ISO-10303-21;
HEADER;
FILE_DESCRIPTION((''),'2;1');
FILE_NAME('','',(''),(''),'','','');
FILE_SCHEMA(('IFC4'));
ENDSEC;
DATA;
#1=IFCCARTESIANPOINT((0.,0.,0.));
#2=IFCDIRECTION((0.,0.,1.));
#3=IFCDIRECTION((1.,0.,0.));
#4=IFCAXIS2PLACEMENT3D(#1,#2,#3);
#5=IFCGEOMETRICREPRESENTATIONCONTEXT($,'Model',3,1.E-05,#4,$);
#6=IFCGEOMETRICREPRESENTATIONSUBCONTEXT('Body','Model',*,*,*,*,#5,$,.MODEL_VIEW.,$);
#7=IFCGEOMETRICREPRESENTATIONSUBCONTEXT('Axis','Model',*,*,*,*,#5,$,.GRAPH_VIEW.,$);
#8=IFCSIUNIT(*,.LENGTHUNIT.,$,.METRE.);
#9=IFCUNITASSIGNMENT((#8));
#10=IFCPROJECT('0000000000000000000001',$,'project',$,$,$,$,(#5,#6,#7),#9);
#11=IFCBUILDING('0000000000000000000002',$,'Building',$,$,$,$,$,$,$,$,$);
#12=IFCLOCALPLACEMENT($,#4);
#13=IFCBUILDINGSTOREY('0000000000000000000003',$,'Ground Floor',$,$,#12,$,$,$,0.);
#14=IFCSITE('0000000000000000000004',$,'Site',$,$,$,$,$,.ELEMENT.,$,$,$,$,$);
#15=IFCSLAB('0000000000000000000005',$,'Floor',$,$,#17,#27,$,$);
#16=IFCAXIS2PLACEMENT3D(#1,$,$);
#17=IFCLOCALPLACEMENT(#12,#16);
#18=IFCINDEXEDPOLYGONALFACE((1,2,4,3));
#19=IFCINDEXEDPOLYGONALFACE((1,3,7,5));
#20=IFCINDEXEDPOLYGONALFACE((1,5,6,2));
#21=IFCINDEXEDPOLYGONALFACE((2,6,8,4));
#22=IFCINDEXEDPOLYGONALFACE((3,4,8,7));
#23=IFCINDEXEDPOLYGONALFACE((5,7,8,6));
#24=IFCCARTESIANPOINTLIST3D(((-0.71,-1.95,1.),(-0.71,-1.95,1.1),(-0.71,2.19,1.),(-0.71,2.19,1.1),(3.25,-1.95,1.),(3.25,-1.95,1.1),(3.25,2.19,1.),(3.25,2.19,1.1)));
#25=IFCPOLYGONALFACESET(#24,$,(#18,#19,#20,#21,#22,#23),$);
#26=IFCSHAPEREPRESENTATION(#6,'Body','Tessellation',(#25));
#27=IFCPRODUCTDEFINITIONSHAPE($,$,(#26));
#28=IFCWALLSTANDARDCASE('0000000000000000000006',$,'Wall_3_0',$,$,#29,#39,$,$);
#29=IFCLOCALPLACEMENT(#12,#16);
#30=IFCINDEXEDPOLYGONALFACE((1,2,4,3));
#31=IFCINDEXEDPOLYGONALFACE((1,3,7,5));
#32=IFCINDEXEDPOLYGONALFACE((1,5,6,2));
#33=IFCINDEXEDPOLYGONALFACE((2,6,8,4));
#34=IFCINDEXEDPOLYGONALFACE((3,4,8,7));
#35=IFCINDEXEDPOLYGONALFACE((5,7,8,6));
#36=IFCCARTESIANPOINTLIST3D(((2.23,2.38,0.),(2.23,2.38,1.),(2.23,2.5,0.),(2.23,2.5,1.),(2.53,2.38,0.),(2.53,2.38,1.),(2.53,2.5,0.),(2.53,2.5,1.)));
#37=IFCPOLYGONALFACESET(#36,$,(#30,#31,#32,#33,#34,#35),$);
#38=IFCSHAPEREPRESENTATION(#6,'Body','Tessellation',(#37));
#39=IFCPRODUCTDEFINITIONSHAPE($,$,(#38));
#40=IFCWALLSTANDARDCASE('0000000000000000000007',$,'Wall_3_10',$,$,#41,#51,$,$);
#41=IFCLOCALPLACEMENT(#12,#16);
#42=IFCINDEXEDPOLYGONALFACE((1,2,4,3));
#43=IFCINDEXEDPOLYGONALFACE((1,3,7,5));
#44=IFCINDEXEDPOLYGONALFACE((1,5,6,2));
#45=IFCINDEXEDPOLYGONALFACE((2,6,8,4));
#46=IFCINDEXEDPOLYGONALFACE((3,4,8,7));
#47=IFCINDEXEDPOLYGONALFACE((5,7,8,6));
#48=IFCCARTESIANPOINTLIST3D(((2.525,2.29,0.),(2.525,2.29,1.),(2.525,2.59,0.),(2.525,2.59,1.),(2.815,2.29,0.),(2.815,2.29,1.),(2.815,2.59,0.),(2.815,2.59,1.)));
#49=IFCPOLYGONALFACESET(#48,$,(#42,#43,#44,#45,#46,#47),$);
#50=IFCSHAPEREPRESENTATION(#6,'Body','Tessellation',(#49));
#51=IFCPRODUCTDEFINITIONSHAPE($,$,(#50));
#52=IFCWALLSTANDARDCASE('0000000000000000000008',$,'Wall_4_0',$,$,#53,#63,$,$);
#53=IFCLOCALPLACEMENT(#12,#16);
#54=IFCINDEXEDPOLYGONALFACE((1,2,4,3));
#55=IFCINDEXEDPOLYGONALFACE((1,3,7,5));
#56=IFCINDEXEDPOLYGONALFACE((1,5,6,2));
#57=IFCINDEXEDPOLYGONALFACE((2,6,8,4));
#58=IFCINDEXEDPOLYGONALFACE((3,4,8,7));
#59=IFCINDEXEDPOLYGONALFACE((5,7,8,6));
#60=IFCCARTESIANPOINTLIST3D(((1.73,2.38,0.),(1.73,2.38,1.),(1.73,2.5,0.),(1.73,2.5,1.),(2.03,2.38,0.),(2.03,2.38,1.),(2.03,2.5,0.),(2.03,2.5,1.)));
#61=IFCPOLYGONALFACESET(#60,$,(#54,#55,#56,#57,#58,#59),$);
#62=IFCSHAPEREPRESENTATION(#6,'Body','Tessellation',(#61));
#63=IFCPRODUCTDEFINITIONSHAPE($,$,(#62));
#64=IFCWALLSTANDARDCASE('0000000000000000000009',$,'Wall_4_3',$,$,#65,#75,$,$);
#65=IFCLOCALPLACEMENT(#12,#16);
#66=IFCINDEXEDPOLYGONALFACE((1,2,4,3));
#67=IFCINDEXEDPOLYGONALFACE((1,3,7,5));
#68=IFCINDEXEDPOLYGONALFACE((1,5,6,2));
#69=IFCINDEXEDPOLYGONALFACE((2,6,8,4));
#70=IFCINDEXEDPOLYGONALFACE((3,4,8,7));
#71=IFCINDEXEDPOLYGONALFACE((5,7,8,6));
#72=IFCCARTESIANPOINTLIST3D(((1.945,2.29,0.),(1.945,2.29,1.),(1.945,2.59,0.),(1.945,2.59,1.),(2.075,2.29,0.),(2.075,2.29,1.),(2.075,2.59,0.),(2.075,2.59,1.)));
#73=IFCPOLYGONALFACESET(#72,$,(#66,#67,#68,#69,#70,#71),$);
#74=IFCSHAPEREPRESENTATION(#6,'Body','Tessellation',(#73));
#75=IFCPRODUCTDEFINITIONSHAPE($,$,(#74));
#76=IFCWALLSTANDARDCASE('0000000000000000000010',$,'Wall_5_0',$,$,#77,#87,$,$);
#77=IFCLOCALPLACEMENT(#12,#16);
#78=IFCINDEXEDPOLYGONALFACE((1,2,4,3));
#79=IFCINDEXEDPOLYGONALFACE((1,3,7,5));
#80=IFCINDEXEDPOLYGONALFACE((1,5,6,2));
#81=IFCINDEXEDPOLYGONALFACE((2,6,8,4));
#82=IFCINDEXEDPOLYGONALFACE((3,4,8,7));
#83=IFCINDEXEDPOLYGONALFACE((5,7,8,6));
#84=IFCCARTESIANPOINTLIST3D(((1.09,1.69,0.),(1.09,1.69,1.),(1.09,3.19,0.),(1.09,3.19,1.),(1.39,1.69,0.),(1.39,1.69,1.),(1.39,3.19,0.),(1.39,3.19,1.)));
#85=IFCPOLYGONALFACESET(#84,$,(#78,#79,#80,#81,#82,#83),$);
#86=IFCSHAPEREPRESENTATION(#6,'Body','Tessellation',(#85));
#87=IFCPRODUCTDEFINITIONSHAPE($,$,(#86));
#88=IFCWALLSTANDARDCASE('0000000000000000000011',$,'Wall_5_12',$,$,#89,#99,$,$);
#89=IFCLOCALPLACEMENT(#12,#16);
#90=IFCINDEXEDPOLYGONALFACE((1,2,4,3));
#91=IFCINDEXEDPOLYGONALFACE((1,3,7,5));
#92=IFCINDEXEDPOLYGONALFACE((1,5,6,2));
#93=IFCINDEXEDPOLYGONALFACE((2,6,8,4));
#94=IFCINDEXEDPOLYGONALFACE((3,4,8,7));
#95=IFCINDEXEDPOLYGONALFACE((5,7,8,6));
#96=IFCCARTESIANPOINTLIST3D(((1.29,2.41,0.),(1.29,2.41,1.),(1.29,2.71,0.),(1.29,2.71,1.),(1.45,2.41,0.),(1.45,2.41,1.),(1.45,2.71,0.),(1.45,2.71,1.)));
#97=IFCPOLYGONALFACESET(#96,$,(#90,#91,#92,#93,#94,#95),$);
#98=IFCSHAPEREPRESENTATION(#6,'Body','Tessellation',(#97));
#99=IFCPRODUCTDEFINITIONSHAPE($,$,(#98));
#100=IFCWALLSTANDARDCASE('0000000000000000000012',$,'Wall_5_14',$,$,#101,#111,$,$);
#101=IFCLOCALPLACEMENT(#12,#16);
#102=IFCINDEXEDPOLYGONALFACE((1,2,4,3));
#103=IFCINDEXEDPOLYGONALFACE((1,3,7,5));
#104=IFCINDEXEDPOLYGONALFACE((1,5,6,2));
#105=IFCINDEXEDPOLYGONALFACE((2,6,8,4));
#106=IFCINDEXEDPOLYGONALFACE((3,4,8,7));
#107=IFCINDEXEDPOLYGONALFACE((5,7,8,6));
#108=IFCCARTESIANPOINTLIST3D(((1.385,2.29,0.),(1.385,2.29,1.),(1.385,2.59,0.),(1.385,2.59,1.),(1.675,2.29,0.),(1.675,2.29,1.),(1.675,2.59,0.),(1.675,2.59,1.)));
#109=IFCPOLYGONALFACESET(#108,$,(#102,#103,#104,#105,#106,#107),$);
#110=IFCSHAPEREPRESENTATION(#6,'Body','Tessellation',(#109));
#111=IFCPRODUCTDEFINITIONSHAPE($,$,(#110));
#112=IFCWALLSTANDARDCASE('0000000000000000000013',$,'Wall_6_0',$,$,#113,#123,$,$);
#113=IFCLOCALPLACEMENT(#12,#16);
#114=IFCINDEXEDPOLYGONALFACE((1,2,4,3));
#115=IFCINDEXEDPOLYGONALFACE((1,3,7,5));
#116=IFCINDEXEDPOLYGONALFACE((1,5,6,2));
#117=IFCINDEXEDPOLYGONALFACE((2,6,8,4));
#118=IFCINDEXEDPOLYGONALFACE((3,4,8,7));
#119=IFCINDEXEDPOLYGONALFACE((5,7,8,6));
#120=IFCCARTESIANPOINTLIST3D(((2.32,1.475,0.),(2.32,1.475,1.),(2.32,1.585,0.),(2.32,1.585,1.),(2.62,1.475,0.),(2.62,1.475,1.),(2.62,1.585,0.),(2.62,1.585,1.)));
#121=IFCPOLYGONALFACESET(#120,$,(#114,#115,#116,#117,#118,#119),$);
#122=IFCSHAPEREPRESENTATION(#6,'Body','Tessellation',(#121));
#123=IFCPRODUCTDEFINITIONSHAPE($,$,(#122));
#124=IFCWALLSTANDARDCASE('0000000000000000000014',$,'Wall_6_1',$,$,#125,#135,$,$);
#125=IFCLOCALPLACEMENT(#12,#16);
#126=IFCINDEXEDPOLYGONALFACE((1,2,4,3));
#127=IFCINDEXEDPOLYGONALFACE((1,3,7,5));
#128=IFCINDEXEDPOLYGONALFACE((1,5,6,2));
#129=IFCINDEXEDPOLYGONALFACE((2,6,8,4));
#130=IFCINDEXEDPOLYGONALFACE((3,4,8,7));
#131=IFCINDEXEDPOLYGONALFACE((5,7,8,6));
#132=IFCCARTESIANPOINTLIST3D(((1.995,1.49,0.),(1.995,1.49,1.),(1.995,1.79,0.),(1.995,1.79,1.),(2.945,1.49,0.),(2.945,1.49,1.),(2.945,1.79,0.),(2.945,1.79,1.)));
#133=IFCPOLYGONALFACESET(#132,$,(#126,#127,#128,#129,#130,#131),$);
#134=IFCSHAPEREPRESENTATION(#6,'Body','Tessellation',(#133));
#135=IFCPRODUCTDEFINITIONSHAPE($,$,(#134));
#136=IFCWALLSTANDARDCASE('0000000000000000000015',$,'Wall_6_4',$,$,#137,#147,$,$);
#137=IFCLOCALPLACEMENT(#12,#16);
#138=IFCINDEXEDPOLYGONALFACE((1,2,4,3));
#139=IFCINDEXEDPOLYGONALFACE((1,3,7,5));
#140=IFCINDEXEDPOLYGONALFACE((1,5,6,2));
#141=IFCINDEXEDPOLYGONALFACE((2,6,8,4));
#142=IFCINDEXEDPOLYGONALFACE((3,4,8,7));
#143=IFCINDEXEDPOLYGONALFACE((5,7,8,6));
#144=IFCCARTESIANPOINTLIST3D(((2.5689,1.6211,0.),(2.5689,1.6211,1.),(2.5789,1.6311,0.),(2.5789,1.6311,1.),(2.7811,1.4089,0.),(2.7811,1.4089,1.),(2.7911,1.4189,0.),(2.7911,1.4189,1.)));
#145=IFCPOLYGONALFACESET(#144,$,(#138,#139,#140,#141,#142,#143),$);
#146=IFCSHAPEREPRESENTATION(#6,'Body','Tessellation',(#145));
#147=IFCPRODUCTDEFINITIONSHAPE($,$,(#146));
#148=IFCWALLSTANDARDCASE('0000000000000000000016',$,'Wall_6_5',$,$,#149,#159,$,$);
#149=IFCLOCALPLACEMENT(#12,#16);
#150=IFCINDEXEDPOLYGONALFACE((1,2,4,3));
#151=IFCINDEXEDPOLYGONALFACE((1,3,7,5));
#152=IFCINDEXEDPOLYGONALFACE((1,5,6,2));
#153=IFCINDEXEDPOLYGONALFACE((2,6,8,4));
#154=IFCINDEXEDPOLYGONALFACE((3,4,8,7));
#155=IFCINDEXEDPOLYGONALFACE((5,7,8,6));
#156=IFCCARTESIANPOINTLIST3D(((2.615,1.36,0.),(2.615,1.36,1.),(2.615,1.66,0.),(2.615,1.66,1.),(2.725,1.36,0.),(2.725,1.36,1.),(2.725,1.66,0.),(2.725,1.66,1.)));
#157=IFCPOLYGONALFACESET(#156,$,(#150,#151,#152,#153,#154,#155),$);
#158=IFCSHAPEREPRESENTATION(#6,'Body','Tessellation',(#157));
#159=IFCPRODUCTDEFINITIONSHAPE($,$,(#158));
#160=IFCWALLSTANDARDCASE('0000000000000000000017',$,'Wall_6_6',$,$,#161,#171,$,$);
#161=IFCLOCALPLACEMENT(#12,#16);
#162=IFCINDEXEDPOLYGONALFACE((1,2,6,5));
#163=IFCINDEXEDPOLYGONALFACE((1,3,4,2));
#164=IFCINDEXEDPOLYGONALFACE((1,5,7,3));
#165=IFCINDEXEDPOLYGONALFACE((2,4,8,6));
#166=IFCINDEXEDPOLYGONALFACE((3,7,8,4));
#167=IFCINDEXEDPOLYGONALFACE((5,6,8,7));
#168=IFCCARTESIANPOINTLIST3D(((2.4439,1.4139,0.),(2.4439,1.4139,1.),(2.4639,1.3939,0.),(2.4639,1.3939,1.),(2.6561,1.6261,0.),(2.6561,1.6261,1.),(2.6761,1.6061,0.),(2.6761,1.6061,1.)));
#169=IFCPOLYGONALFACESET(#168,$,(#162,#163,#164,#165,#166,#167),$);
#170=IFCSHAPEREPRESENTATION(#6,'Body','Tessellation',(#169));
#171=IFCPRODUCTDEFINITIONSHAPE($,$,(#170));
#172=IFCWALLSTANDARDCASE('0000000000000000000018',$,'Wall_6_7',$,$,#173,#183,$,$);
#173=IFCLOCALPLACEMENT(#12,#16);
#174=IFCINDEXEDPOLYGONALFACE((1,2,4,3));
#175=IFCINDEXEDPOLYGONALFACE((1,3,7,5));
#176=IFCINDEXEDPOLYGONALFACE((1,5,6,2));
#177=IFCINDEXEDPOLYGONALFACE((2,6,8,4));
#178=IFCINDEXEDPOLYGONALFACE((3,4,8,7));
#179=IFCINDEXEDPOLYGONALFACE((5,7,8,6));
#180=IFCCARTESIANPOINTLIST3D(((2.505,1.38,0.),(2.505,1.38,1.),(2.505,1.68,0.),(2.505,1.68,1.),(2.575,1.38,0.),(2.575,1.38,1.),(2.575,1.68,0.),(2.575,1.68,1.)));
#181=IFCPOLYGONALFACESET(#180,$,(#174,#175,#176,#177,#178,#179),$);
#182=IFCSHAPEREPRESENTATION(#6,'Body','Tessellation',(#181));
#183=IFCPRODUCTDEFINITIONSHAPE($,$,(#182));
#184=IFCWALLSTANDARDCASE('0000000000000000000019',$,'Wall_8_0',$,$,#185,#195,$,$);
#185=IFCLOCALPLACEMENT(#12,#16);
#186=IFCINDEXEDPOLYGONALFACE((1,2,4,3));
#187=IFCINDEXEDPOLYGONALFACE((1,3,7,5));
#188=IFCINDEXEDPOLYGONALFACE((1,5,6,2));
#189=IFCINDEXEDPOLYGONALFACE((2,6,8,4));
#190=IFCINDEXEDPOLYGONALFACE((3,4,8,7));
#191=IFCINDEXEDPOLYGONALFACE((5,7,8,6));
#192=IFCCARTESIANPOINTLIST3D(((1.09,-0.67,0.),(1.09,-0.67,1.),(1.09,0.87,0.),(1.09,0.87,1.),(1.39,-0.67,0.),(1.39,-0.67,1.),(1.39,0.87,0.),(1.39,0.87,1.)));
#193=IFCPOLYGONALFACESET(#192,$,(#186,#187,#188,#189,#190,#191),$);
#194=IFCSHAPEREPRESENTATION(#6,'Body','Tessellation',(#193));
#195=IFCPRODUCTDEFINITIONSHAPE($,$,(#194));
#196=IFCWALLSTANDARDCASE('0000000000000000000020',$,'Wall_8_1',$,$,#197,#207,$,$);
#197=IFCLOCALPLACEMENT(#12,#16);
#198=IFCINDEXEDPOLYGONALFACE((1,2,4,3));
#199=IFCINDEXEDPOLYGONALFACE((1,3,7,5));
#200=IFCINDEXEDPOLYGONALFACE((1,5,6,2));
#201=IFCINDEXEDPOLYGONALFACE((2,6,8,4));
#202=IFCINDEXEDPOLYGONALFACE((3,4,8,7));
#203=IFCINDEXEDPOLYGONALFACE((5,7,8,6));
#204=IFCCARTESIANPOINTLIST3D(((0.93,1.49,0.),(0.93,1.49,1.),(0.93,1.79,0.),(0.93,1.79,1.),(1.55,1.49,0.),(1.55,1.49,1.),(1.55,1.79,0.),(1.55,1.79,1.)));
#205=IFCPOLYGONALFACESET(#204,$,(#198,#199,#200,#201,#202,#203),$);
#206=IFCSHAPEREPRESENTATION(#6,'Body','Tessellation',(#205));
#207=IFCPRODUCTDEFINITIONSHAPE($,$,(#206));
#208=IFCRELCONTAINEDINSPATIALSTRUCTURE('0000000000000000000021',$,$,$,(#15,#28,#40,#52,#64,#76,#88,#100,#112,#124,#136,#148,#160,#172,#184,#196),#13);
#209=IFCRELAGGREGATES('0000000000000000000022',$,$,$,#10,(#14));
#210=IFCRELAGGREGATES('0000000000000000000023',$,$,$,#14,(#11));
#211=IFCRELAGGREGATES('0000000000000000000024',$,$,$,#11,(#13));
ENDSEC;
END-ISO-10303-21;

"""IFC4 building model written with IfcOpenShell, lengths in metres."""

from ifc_helpers import new_model, si_unit, frame, origin_with_axes, origin_2d, place, context, subcontext, project, spatial, rectangle, extrude, element, save


model = new_model("IFC4")

# Units and contexts
model_context = context("Model", 3, precision=1e-05, world=origin_with_axes())
body_context = subcontext(model_context, "Body", "Model", "MODEL_VIEW")
axis_context = subcontext(model_context, "Axis", "Model", "GRAPH_VIEW")
ifc_project = project(units=[si_unit("LENGTHUNIT", "METRE")], contexts=[model_context, body_context, axis_context])

# Site, building, storey
site = spatial("IfcSite", under=ifc_project, Name="Site", CompositionType="ELEMENT")
building = spatial("IfcBuilding", under=site, Name="Building")
storey_placement = place(None, origin_with_axes())
storey = spatial("IfcBuildingStorey", under=building, at=storey_placement, Name="Ground Floor", Elevation=0.0)

# Slab
slab_placement = place(storey_placement, origin_with_axes())
element("IfcSlab", 1, at=slab_placement, inside=storey, Name="Floor", context=body_context, shape_type="SweptSolid", body=[
    extrude(rectangle(XDim=3.96, YDim=4.14, at=origin_2d()), frame((1.27, 0.12, 1.0), z_axis=(0.0, 0.0, 1.0), x_axis=(1.0, 0.0, 0.0)), (0.0, 0.0, 1.0), 0.1),
])

# Walls
wall_1_placement = place(storey_placement, frame((2.38, 2.44, 0.0), z_axis=(0.0, 0.0, 1.0), x_axis=(0.0, 1.0, 0.0)))
element("IfcWallStandardCase", 2, at=wall_1_placement, inside=storey, Name="Wall_3_0", context=body_context, shape_type="SweptSolid", body=[
    extrude(rectangle(XDim=0.12, YDim=0.3, at=origin_2d()), origin_with_axes(), (0.0, 0.0, 1.0), 1.0),
])
wall_2_placement = place(storey_placement, frame((2.67, 2.44, 0.0), z_axis=(0.0, 0.0, 1.0), x_axis=(-1.0, 0.0, 0.0)))
element("IfcWallStandardCase", 3, at=wall_2_placement, inside=storey, Name="Wall_3_10", context=body_context, shape_type="SweptSolid", body=[
    extrude(rectangle(XDim=0.29, YDim=0.3, at=origin_2d()), origin_with_axes(), (0.0, 0.0, 1.0), 1.0),
])
wall_3_placement = place(storey_placement, frame((1.88, 2.44, 0.0), z_axis=(0.0, 0.0, 1.0), x_axis=(0.0, 1.0, 0.0)))
element("IfcWallStandardCase", 4, at=wall_3_placement, inside=storey, Name="Wall_4_0", context=body_context, shape_type="SweptSolid", body=[
    extrude(rectangle(XDim=0.12, YDim=0.3, at=origin_2d()), origin_with_axes(), (0.0, 0.0, 1.0), 1.0),
])
wall_4_placement = place(storey_placement, frame((2.01, 2.44, 0.0), z_axis=(0.0, 0.0, 1.0), x_axis=(-1.0, 0.0, 0.0)))
element("IfcWallStandardCase", 5, at=wall_4_placement, inside=storey, Name="Wall_4_3", context=body_context, shape_type="SweptSolid", body=[
    extrude(rectangle(XDim=0.13, YDim=0.3, at=origin_2d()), origin_with_axes(), (0.0, 0.0, 1.0), 1.0),
])
wall_5_placement = place(storey_placement, frame((1.24, 2.44, 0.0), z_axis=(0.0, 0.0, 1.0), x_axis=(0.0, 1.0, 0.0)))
element("IfcWallStandardCase", 6, at=wall_5_placement, inside=storey, Name="Wall_5_0", context=body_context, shape_type="SweptSolid", body=[
    extrude(rectangle(XDim=1.5, YDim=0.3, at=origin_2d()), origin_with_axes(), (0.0, 0.0, 1.0), 1.0),
])
wall_6_placement = place(storey_placement, frame((1.37, 2.56, 0.0), z_axis=(0.0, 0.0, 1.0), x_axis=(1.0, 0.0, 0.0)))
element("IfcWallStandardCase", 7, at=wall_6_placement, inside=storey, Name="Wall_5_12", context=body_context, shape_type="SweptSolid", body=[
    extrude(rectangle(XDim=0.16, YDim=0.3, at=origin_2d()), origin_with_axes(), (0.0, 0.0, 1.0), 1.0),
])
wall_7_placement = place(storey_placement, frame((1.53, 2.44, 0.0), z_axis=(0.0, 0.0, 1.0), x_axis=(-1.0, 0.0, 0.0)))
element("IfcWallStandardCase", 8, at=wall_7_placement, inside=storey, Name="Wall_5_14", context=body_context, shape_type="SweptSolid", body=[
    extrude(rectangle(XDim=0.29, YDim=0.3, at=origin_2d()), origin_with_axes(), (0.0, 0.0, 1.0), 1.0),
])
wall_8_placement = place(storey_placement, frame((2.47, 1.53, 0.0), z_axis=(0.0, 0.0, 1.0), x_axis=(0.0, 1.0, 0.0)))
element("IfcWallStandardCase", 9, at=wall_8_placement, inside=storey, Name="Wall_6_0", context=body_context, shape_type="SweptSolid", body=[
    extrude(rectangle(XDim=0.11, YDim=0.3, at=origin_2d()), origin_with_axes(), (0.0, 0.0, 1.0), 1.0),
])
wall_9_placement = place(storey_placement, frame((2.47, 1.64, 0.0), z_axis=(0.0, 0.0, 1.0), x_axis=(1.0, 0.0, 0.0)))
element("IfcWallStandardCase", 10, at=wall_9_placement, inside=storey, Name="Wall_6_1", context=body_context, shape_type="SweptSolid", body=[
    extrude(rectangle(XDim=0.95, YDim=0.3, at=origin_2d()), origin_with_axes(), (0.0, 0.0, 1.0), 1.0),
])
wall_10_placement = place(storey_placement, frame((2.68, 1.52, 0.0), z_axis=(0.0, 0.0, 1.0), x_axis=(-0.707107, -0.707107, 0.0)))
element("IfcWallStandardCase", 11, at=wall_10_placement, inside=storey, Name="Wall_6_4", context=body_context, shape_type="SweptSolid", body=[
    extrude(rectangle(XDim=0.0141, YDim=0.3, at=origin_2d()), origin_with_axes(), (0.0, 0.0, 1.0), 1.0),
])
wall_11_placement = place(storey_placement, frame((2.67, 1.51, 0.0), z_axis=(0.0, 0.0, 1.0), x_axis=(-1.0, 0.0, 0.0)))
element("IfcWallStandardCase", 12, at=wall_11_placement, inside=storey, Name="Wall_6_5", context=body_context, shape_type="SweptSolid", body=[
    extrude(rectangle(XDim=0.11, YDim=0.3, at=origin_2d()), origin_with_axes(), (0.0, 0.0, 1.0), 1.0),
])
wall_12_placement = place(storey_placement, frame((2.56, 1.51, 0.0), z_axis=(0.0, 0.0, 1.0), x_axis=(-0.707107, 0.707107, 0.0)))
element("IfcWallStandardCase", 13, at=wall_12_placement, inside=storey, Name="Wall_6_6", context=body_context, shape_type="SweptSolid", body=[
    extrude(rectangle(XDim=0.0283, YDim=0.3, at=origin_2d()), origin_with_axes(), (0.0, 0.0, 1.0), 1.0),
])
wall_13_placement = place(storey_placement, frame((2.54, 1.53, 0.0), z_axis=(0.0, 0.0, 1.0), x_axis=(-1.0, 0.0, 0.0)))
element("IfcWallStandardCase", 14, at=wall_13_placement, inside=storey, Name="Wall_6_7", context=body_context, shape_type="SweptSolid", body=[
    extrude(rectangle(XDim=0.07, YDim=0.3, at=origin_2d()), origin_with_axes(), (0.0, 0.0, 1.0), 1.0),
])
wall_14_placement = place(storey_placement, frame((1.24, 0.1, 0.0), z_axis=(0.0, 0.0, 1.0), x_axis=(0.0, 1.0, 0.0)))
element("IfcWallStandardCase", 15, at=wall_14_placement, inside=storey, Name="Wall_8_0", context=body_context, shape_type="SweptSolid", body=[
    extrude(rectangle(XDim=1.54, YDim=0.3, at=origin_2d()), origin_with_axes(), (0.0, 0.0, 1.0), 1.0),
])
wall_15_placement = place(storey_placement, frame((1.24, 1.64, 0.0), z_axis=(0.0, 0.0, 1.0), x_axis=(1.0, 0.0, 0.0)))
element("IfcWallStandardCase", 16, at=wall_15_placement, inside=storey, Name="Wall_8_1", context=body_context, shape_type="SweptSolid", body=[
    extrude(rectangle(XDim=0.62, YDim=0.3, at=origin_2d()), origin_with_axes(), (0.0, 0.0, 1.0), 1.0),
])

save(model, "model.ifc")
